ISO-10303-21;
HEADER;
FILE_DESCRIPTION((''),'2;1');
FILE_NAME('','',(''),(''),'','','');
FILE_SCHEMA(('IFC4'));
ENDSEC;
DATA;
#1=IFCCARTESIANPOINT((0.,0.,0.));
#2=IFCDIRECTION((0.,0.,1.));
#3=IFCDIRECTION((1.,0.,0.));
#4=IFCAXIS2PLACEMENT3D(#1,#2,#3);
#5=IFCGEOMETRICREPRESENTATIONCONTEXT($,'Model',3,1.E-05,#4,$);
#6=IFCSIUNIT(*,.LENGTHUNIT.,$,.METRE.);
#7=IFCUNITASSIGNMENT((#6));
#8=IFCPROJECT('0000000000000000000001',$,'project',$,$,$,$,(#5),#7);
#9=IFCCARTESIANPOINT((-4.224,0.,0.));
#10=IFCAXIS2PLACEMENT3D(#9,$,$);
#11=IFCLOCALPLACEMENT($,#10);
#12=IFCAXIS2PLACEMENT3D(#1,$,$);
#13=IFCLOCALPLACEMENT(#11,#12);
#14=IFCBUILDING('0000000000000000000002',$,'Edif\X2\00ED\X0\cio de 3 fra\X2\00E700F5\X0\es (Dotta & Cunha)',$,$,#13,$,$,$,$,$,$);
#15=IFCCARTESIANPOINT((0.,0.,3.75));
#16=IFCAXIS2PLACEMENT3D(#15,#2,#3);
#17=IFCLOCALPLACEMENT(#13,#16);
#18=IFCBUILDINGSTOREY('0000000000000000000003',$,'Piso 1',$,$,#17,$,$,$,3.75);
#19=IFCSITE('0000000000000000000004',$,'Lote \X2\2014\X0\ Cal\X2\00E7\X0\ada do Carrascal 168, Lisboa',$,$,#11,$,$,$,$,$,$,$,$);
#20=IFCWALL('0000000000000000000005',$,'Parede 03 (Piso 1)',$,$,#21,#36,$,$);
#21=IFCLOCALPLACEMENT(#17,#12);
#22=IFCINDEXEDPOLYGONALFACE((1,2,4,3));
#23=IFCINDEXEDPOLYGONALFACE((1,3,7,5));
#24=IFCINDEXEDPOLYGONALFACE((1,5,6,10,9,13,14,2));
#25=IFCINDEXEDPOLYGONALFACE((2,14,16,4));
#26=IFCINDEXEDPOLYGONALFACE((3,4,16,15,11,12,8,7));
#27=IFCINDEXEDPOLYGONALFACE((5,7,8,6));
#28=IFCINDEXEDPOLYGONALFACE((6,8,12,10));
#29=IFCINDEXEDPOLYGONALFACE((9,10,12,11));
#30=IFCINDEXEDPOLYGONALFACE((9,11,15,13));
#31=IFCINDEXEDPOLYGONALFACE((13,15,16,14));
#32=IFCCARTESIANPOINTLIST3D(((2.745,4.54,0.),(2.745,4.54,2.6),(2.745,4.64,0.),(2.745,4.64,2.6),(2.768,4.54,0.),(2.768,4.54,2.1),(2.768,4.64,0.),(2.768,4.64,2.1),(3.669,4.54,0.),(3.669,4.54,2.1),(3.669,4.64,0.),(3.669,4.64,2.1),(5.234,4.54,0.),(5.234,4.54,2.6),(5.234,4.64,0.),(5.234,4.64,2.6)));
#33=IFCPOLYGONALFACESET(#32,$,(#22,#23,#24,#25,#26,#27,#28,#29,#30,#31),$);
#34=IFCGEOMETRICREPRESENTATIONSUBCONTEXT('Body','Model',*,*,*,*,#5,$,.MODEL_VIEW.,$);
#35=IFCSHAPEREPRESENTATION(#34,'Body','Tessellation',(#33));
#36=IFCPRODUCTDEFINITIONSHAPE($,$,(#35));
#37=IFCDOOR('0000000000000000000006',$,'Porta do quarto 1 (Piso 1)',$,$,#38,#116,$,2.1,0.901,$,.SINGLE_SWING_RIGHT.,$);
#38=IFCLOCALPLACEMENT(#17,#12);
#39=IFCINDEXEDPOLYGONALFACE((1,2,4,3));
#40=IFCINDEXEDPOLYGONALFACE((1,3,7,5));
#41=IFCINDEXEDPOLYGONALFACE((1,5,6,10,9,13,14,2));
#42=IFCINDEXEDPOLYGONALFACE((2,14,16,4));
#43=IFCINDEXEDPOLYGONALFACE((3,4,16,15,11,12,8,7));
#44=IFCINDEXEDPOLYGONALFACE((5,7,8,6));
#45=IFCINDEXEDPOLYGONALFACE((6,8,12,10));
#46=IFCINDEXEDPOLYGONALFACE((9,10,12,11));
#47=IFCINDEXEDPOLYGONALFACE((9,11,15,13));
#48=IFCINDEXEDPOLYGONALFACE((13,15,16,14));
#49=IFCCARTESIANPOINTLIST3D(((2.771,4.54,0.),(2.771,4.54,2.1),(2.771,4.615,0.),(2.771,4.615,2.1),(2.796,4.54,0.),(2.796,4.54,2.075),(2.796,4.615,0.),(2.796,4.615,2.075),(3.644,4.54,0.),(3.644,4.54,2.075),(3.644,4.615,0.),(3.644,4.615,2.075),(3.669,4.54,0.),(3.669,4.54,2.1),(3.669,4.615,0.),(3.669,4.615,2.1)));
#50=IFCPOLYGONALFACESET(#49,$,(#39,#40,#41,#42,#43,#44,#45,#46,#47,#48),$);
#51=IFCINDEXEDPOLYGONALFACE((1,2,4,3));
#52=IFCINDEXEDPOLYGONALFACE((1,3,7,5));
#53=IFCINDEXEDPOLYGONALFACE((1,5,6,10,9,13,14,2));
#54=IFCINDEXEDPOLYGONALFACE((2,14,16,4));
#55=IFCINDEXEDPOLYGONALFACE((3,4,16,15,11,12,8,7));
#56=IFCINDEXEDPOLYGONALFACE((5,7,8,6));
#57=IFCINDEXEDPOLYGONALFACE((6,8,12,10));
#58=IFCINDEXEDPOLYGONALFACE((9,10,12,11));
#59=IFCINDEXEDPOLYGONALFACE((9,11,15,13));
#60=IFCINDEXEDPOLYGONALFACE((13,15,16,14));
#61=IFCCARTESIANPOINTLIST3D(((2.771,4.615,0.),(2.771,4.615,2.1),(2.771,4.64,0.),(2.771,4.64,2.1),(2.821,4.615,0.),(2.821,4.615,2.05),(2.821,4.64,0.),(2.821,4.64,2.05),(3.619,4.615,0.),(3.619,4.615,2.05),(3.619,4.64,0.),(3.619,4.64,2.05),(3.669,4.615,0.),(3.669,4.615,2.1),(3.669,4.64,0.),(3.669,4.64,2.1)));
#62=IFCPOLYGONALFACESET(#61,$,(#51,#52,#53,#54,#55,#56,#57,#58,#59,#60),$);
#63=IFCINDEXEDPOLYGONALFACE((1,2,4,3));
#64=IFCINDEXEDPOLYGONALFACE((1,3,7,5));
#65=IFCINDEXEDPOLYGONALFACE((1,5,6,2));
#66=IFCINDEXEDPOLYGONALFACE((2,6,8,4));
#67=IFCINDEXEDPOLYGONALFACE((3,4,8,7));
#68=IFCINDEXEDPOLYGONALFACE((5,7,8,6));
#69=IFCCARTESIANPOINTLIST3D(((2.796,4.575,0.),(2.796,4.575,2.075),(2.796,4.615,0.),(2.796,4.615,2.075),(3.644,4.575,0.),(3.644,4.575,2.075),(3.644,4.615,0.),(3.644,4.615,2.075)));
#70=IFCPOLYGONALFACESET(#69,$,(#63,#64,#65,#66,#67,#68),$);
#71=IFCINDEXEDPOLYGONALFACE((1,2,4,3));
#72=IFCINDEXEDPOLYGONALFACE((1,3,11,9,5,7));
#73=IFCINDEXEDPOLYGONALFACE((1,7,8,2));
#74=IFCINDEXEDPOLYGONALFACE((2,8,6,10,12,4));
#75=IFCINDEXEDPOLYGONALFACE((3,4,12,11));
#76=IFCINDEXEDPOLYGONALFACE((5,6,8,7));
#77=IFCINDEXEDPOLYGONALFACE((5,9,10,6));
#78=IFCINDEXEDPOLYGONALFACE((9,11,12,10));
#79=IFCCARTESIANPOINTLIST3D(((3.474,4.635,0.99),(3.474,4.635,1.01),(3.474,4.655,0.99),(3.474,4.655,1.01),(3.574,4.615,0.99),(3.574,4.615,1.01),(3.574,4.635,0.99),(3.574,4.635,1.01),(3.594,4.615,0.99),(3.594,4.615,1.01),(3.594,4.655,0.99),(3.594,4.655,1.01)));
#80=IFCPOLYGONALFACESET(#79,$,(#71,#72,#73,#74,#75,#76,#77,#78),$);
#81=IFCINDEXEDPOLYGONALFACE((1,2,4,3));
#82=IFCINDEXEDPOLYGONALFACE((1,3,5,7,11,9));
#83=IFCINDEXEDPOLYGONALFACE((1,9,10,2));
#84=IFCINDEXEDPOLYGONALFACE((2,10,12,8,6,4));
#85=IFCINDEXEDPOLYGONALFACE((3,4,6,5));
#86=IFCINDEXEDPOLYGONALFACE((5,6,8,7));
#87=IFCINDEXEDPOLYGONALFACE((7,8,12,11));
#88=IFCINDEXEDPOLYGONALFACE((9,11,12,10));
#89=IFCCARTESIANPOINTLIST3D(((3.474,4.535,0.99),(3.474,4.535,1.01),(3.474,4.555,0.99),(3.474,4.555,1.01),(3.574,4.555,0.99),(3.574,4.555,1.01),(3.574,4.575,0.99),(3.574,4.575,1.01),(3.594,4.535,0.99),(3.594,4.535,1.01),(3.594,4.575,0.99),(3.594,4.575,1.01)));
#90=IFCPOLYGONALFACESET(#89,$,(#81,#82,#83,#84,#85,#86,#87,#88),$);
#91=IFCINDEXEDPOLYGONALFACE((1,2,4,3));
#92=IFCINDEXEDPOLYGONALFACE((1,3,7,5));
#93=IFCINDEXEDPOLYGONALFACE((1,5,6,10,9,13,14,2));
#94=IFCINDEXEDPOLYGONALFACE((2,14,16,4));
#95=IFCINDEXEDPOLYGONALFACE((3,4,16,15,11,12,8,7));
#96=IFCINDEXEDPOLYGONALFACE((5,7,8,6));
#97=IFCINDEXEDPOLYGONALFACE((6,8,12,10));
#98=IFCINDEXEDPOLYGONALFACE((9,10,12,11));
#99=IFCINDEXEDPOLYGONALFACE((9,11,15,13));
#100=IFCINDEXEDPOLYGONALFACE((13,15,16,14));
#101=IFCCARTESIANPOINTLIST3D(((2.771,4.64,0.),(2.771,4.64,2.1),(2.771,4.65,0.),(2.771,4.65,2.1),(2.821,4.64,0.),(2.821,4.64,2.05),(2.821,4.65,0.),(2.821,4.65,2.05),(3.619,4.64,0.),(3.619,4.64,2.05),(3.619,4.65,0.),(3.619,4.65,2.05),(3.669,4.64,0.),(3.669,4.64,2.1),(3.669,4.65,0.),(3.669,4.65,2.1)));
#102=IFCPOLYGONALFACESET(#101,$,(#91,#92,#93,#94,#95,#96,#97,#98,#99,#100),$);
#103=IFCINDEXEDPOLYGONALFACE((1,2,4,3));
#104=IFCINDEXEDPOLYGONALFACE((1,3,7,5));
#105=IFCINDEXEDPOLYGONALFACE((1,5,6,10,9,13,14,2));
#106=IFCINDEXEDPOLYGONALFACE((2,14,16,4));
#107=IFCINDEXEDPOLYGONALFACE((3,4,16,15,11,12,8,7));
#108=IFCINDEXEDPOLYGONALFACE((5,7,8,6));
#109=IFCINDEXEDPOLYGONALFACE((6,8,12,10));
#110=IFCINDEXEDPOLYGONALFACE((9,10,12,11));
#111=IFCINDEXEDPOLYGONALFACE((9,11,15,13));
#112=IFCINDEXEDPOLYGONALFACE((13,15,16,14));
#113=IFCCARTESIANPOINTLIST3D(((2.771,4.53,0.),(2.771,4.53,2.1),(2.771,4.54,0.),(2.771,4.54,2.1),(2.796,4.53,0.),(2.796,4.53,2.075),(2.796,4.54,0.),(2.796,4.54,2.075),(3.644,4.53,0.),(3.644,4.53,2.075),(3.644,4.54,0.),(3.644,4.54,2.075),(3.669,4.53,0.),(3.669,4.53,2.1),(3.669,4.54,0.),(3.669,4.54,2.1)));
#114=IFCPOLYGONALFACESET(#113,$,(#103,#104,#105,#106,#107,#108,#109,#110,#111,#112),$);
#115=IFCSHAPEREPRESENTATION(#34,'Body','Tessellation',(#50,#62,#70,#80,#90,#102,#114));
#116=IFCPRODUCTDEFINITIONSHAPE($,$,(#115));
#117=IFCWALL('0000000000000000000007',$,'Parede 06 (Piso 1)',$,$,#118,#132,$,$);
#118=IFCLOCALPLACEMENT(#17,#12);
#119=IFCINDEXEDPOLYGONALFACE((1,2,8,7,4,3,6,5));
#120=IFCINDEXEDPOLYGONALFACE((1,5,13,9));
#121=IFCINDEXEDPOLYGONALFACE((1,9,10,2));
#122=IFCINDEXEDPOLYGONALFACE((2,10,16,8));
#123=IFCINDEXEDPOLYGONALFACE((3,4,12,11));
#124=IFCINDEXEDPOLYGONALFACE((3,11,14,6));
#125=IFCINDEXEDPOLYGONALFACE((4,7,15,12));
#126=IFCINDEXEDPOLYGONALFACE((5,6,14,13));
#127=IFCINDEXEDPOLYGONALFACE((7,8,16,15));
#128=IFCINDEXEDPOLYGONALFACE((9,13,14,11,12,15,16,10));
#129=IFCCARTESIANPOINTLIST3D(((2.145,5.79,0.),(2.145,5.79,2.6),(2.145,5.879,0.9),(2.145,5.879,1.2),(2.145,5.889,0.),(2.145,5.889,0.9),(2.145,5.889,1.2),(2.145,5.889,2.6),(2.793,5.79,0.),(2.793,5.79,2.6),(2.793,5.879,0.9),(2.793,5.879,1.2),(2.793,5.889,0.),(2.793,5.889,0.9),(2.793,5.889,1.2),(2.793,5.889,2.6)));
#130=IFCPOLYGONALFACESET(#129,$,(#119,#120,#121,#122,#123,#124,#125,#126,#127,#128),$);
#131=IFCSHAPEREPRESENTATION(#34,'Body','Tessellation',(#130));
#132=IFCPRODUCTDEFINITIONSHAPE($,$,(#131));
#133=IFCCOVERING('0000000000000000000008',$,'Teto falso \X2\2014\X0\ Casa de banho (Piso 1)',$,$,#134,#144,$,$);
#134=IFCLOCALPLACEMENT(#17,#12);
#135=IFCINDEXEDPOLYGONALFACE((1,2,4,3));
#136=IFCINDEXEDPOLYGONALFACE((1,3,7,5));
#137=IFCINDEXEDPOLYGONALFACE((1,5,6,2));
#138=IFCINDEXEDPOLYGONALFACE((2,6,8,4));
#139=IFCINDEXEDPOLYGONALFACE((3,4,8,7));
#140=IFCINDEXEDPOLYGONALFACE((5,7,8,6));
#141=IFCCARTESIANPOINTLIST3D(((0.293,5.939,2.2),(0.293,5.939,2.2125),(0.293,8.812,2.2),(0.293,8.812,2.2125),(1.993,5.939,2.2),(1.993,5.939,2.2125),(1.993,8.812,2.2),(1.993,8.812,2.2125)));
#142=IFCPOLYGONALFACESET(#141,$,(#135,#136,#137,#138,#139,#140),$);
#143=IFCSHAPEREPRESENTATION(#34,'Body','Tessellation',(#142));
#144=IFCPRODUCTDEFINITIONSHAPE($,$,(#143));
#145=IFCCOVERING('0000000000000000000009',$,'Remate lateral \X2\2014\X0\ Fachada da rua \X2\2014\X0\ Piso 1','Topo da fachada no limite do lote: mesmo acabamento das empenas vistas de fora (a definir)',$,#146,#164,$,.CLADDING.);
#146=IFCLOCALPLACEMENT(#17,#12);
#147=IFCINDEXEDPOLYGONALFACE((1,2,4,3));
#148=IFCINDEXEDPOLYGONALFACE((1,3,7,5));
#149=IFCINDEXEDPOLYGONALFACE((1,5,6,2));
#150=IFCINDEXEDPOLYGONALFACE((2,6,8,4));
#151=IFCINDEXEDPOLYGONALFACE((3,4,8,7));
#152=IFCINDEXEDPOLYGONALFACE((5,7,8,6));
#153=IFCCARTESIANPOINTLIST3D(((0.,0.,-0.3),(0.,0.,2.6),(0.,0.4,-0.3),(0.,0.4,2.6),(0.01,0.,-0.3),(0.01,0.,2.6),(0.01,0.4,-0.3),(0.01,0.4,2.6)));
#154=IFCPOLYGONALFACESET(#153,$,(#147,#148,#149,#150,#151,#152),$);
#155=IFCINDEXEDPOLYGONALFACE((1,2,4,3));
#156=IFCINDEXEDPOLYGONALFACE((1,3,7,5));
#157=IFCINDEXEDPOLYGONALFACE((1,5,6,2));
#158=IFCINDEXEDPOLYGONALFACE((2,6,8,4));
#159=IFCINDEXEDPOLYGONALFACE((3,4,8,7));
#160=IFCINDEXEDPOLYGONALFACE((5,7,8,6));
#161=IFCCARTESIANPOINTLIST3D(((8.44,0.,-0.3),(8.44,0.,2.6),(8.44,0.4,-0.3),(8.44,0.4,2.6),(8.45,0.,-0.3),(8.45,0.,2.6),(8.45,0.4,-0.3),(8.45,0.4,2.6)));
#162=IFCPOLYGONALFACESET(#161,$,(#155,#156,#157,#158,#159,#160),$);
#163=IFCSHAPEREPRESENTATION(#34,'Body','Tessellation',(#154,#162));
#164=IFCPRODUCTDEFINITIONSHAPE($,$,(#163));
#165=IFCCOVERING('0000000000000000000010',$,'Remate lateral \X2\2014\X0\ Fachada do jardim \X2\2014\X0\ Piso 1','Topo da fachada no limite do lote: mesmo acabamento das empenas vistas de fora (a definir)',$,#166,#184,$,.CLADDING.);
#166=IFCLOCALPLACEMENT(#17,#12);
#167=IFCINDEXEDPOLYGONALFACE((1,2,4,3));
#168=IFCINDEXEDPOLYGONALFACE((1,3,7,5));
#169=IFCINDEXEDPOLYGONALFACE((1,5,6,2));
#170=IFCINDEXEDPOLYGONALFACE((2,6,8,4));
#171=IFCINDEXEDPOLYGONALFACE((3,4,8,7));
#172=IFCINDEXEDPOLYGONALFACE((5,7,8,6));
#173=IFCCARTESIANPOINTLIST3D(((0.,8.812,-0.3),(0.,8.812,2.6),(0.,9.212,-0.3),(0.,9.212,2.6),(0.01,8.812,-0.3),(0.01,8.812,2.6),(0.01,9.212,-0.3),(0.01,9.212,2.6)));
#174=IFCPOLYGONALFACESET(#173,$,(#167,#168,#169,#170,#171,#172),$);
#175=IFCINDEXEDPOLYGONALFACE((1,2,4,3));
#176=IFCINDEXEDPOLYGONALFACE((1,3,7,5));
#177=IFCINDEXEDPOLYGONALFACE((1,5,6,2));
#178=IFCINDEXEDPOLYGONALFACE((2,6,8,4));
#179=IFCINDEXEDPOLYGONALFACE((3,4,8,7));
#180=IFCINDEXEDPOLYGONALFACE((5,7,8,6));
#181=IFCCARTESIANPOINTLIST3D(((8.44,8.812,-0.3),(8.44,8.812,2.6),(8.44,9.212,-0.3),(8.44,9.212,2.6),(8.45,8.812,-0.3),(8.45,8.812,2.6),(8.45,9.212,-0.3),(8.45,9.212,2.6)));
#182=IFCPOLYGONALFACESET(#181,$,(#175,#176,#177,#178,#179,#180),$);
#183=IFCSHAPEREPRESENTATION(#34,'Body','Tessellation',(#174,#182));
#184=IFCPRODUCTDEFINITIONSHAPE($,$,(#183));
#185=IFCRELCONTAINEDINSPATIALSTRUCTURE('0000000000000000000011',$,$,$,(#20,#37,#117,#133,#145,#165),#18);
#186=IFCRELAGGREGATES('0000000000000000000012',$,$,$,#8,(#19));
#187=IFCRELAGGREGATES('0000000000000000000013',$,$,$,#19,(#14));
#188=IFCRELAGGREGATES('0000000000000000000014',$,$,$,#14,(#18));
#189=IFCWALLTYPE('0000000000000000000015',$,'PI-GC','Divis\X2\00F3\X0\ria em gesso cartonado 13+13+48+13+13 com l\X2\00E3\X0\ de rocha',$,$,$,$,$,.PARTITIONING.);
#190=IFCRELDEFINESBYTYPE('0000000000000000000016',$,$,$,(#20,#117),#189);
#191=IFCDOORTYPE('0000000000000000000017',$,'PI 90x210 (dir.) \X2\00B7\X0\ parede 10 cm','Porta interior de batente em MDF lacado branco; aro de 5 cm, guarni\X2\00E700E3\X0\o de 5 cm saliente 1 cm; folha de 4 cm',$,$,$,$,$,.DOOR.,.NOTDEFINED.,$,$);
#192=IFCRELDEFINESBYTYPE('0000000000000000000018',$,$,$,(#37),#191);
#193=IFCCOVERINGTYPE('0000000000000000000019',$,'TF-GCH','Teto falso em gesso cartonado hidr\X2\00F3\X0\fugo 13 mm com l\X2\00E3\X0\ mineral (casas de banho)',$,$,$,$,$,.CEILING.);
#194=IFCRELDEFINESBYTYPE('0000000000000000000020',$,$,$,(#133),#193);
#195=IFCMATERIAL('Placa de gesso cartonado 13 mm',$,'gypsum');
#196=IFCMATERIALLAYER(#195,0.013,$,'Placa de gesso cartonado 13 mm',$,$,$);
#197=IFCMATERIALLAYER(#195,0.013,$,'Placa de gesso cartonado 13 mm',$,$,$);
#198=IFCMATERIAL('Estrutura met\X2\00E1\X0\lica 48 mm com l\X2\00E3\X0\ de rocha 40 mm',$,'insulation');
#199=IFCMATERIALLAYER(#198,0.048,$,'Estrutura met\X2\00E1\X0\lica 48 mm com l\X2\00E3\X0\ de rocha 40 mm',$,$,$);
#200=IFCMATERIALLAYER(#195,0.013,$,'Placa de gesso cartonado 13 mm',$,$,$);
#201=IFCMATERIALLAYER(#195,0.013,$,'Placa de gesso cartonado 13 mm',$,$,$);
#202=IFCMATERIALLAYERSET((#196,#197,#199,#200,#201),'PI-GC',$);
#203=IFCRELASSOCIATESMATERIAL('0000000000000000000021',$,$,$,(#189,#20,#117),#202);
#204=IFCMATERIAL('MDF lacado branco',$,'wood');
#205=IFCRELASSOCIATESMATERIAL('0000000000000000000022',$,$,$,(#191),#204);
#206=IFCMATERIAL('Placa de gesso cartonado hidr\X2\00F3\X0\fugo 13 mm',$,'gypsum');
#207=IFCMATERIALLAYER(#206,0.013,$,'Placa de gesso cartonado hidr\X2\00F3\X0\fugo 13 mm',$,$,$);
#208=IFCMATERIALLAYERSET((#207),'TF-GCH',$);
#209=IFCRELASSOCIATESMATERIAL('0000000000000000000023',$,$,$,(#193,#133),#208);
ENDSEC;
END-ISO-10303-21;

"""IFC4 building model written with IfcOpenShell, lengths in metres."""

from ifc_helpers import new_model, si_unit, frame, origin, origin_with_axes, place, context, subcontext, project, spatial, line, indexed_curve, outline, extrude, source, transform, mapped, material, layer, layer_set, layer_usage, type_object, type_shapes, element, fill, save


model = new_model("IFC4")

# Units and contexts
model_context = context("Model", 3, precision=1e-05, world=origin_with_axes())
body_context = subcontext(model_context, "Body", "Model", "MODEL_VIEW")
ifc_project = project(units=[si_unit("LENGTHUNIT", "METRE")], contexts=[model_context])

# Site, building, storey
site_placement = place(None, frame((-4.224, 0.0, 0.0)))
site = spatial("IfcSite", under=ifc_project, at=site_placement, Name="Lote — Calçada do Carrascal 168, Lisboa")
building_placement = place(site_placement, origin())
building = spatial("IfcBuilding", under=site, at=building_placement, Name="Edifício de 3 frações (Dotta & Cunha)")
storey_placement = place(building_placement, frame((0.0, 0.0, 3.75), z_axis=(0.0, 0.0, 1.0), x_axis=(1.0, 0.0, 0.0)))
storey = spatial("IfcBuildingStorey", under=building, at=storey_placement, Name="Piso 1", Elevation=3.75)

# Shared definitions
ifc_material_1 = material(Name="MDF lacado branco", Category="wood")

# Shared definitions
ifc_material_2 = material(Name="Placa de gesso cartonado 13 mm", Category="gypsum")
ifc_layer_1 = layer(ifc_material_2, 0.013, Name="Placa de gesso cartonado 13 mm")
ifc_layer_2 = layer(ifc_material_2, 0.013, Name="Placa de gesso cartonado 13 mm")
ifc_material_3 = material(Name="Estrutura metálica 48 mm com lã de rocha 40 mm", Category="insulation")
ifc_layer_3 = layer(ifc_material_3, 0.048, Name="Estrutura metálica 48 mm com lã de rocha 40 mm")
ifc_layer_4 = layer(ifc_material_2, 0.013, Name="Placa de gesso cartonado 13 mm")
ifc_layer_5 = layer(ifc_material_2, 0.013, Name="Placa de gesso cartonado 13 mm")
ifc_layer_set_1 = layer_set([ifc_layer_1, ifc_layer_2, ifc_layer_3, ifc_layer_4, ifc_layer_5], Name="PI-GC")
wall_type_1 = type_object("IfcWallType", Name="PI-GC", Description="Divisória em gesso cartonado 13+13+48+13+13 com lã de rocha", PredefinedType="PARTITIONING", material=ifc_layer_set_1)

# Wall, opening, door
door_type_1 = type_object("IfcDoorType", Name="PI 90x210 (dir.) · parede 10 cm", Description="Porta interior de batente em MDF lacado branco; aro de 5 cm, guarnição de 5 cm saliente 1 cm; folha de 4 cm", OperationType="NOTDEFINED", PredefinedType="DOOR", material=ifc_material_1)
shared_shape_1 = source(origin_with_axes(), body_context, "Body", "SweptSolid", [
    extrude(outline(indexed_curve([(0.0, 0.0), (0.0, 2.1), (0.898, 2.1), (0.898, 0.0), (0.873, 0.0), (0.873, 2.075), (0.025, 2.075), (0.025, 0.0)], segments=[line(1, 2, 3, 4, 5, 6, 7, 8, 1)])), frame((0.0, 0.025, 0.0), z_axis=(0.0, -1.0, 0.0), x_axis=(1.0, 0.0, 0.0)), (0.0, 0.0, -1.0), 0.075),
    extrude(outline(indexed_curve([(0.0, 0.0), (0.0, 2.1), (0.898, 2.1), (0.898, 0.0), (0.848, 0.0), (0.848, 2.05), (0.05, 2.05), (0.05, 0.0)], segments=[line(1, 2, 3, 4, 5, 6, 7, 8, 1)])), frame((0.0, 0.0, 0.0), z_axis=(0.0, -1.0, 0.0), x_axis=(1.0, 0.0, 0.0)), (0.0, 0.0, -1.0), 0.025),
    extrude(outline(indexed_curve([(0.0, 0.0), (0.848, 0.0), (0.848, 0.04), (0.0, 0.04)], segments=[line(1, 2, 3, 4, 1)])), frame((0.025, 0.025, 0.0), z_axis=(0.0, 0.0, 1.0), x_axis=(1.0, 0.0, 0.0)), (0.0, 0.0, 1.0), 2.075),
    extrude(outline(indexed_curve([(0.0, 0.0), (0.0, -0.04), (0.12, -0.04), (0.12, -0.02), (0.02, -0.02), (0.02, 0.0)], segments=[line(1, 2, 3, 4, 5, 6, 1)])), frame((0.075, 0.025, 0.99), z_axis=(0.0, 0.0, 1.0), x_axis=(1.0, 0.0, 0.0)), (0.0, 0.0, 1.0), 0.02),
    extrude(outline(indexed_curve([(0.0, 0.0), (0.0, 0.04), (0.12, 0.04), (0.12, 0.02), (0.02, 0.02), (0.02, 0.0)], segments=[line(1, 2, 3, 4, 5, 6, 1)])), frame((0.075, 0.065, 0.99), z_axis=(0.0, 0.0, 1.0), x_axis=(1.0, 0.0, 0.0)), (0.0, 0.0, 1.0), 0.02),
    extrude(outline(indexed_curve([(0.0, 0.0), (0.0, 2.1), (0.898, 2.1), (0.898, 0.0), (0.848, 0.0), (0.848, 2.05), (0.05, 2.05), (0.05, 0.0)], segments=[line(1, 2, 3, 4, 5, 6, 7, 8, 1)])), frame((0.0, -0.01, 0.0), z_axis=(0.0, -1.0, 0.0), x_axis=(1.0, 0.0, 0.0)), (0.0, 0.0, -1.0), 0.01),
    extrude(outline(indexed_curve([(0.0, 0.0), (0.0, 2.1), (0.898, 2.1), (0.898, 0.0), (0.873, 0.0), (0.873, 2.075), (0.025, 2.075), (0.025, 0.0)], segments=[line(1, 2, 3, 4, 5, 6, 7, 8, 1)])), frame((0.0, 0.1, 0.0), z_axis=(0.0, -1.0, 0.0), x_axis=(1.0, 0.0, 0.0)), (0.0, 0.0, -1.0), 0.01),
])
type_shapes(door_type_1, [shared_shape_1])
ifc_layer_usage_1 = layer_usage(ifc_layer_set_1, "AXIS2", "POSITIVE", 0.0)
wall_1_placement = place(storey_placement, origin_with_axes())
wall_1 = element("IfcWall", 1, at=wall_1_placement, inside=storey, type_object=wall_type_1, material=ifc_layer_usage_1, Name="Parede 03 (Piso 1)", context=body_context, shape_type="SweptSolid", body=[
    extrude(outline(indexed_curve([(5.234, 4.54), (5.234, 4.64), (2.745, 4.64), (2.745, 4.54)], segments=[line(1, 2, 3, 4, 1)])), origin_with_axes(), (0.0, 0.0, 1.0), 2.6),
])
opening_1_placement = place(wall_1_placement, origin_with_axes())
opening_1 = element("IfcOpeningElement", 2, at=opening_1_placement, cuts=wall_1, context=body_context, shape_type="SweptSolid", body=[
    extrude(outline(indexed_curve([(3.669, 4.538), (3.669, 4.642), (2.768, 4.642), (2.768, 4.538)], segments=[line(1, 2, 3, 4, 1)])), origin_with_axes(), (0.0, 0.0, 1.0), 2.1),
])
door_1_placement = place(storey_placement, frame((3.669, 4.64, 0.0), z_axis=(0.0, 0.0, 1.0), x_axis=(-1.0, 0.0, 0.0)))
door_1 = element("IfcDoor", 3, at=door_1_placement, inside=storey, type_object=door_type_1, Name="Porta do quarto 1 (Piso 1)", OperationType="SINGLE_SWING_RIGHT", OverallHeight=2.1, OverallWidth=0.901, context=body_context, shape_type="MappedRepresentation", body=[
    mapped(shared_shape_1, transform((0.0, 0.0, 0.0), x_axis=(1.0, 0.0, 0.0), y_axis=(0.0, 1.0, 0.0), z_axis=(0.0, 0.0, 1.0), scale=1.0)),
])
fill(opening_1, door_1)

# Wall, opening
ifc_layer_usage_2 = layer_usage(ifc_layer_set_1, "AXIS2", "POSITIVE", 0.0)
wall_2_placement = place(storey_placement, origin_with_axes())
wall_2 = element("IfcWall", 4, at=wall_2_placement, inside=storey, type_object=wall_type_1, material=ifc_layer_usage_2, Name="Parede 06 (Piso 1)", context=body_context, shape_type="SweptSolid", body=[
    extrude(outline(indexed_curve([(2.793, 5.79), (2.793, 5.889), (2.145, 5.889), (2.145, 5.79)], segments=[line(1, 2, 3, 4, 1)])), origin_with_axes(), (0.0, 0.0, 1.0), 2.6),
])
opening_2_placement = place(wall_2_placement, frame((0.0, 0.0, 0.9), z_axis=(0.0, 0.0, 1.0), x_axis=(1.0, 0.0, 0.0)))
element("IfcOpeningElement", 5, at=opening_2_placement, cuts=wall_2, PredefinedType="RECESS", context=body_context, shape_type="SweptSolid", body=[
    extrude(outline(indexed_curve([(2.793, 5.879), (2.793, 5.894), (2.145, 5.894), (2.145, 5.879)], segments=[line(1, 2, 3, 4, 1)])), origin_with_axes(), (0.0, 0.0, 1.0), 0.3),
])

# Coverings
ifc_material_4 = material(Name="Placa de gesso cartonado hidrófugo 13 mm", Category="gypsum")
ifc_layer_6 = layer(ifc_material_4, 0.013, Name="Placa de gesso cartonado hidrófugo 13 mm")
ifc_layer_set_2 = layer_set([ifc_layer_6], Name="TF-GCH")
ifc_layer_usage_3 = layer_usage(ifc_layer_set_2, "AXIS3", "POSITIVE", 0.0)
covering_type_1 = type_object("IfcCoveringType", Name="TF-GCH", Description="Teto falso em gesso cartonado hidrófugo 13 mm com lã mineral (casas de banho)", PredefinedType="CEILING", material=ifc_layer_set_2)
covering_1_placement = place(storey_placement, frame((0.0, 0.0, 2.2), z_axis=(0.0, 0.0, 1.0), x_axis=(1.0, 0.0, 0.0)))
element("IfcCovering", 6, at=covering_1_placement, inside=storey, type_object=covering_type_1, material=ifc_layer_usage_3, Name="Teto falso — Casa de banho (Piso 1)", context=body_context, shape_type="SweptSolid", body=[
    extrude(outline(indexed_curve([(0.293, 8.812), (1.993, 8.812), (1.993, 5.939), (0.293, 5.939)], segments=[line(1, 2, 3, 4, 1)])), origin_with_axes(), (0.0, 0.0, 1.0), 0.0125),
])
covering_2_placement = place(storey_placement, frame((0.0, 0.0, -0.3), z_axis=(0.0, 0.0, 1.0), x_axis=(1.0, 0.0, 0.0)))
element("IfcCovering", 7, at=covering_2_placement, inside=storey, Name="Remate lateral — Fachada da rua — Piso 1", Description="Topo da fachada no limite do lote: mesmo acabamento das empenas vistas de fora (a definir)", PredefinedType="CLADDING", context=body_context, shape_type="SweptSolid", body=[
    extrude(outline(indexed_curve([(0.0, 0.0), (0.0, 0.4), (0.01, 0.4), (0.01, 0.0)], segments=[line(1, 2, 3, 4, 1)])), origin_with_axes(), (0.0, 0.0, 1.0), 2.9),
    extrude(outline(indexed_curve([(8.44, 0.0), (8.44, 0.4), (8.45, 0.4), (8.45, 0.0)], segments=[line(1, 2, 3, 4, 1)])), origin_with_axes(), (0.0, 0.0, 1.0), 2.9),
])
covering_3_placement = place(storey_placement, frame((0.0, 0.0, -0.3), z_axis=(0.0, 0.0, 1.0), x_axis=(1.0, 0.0, 0.0)))
element("IfcCovering", 8, at=covering_3_placement, inside=storey, Name="Remate lateral — Fachada do jardim — Piso 1", Description="Topo da fachada no limite do lote: mesmo acabamento das empenas vistas de fora (a definir)", PredefinedType="CLADDING", context=body_context, shape_type="SweptSolid", body=[
    extrude(outline(indexed_curve([(0.0, 8.812), (0.0, 9.212), (0.01, 9.212), (0.01, 8.812)], segments=[line(1, 2, 3, 4, 1)])), origin_with_axes(), (0.0, 0.0, 1.0), 2.9),
    extrude(outline(indexed_curve([(8.44, 8.812), (8.44, 9.212), (8.45, 9.212), (8.45, 8.812)], segments=[line(1, 2, 3, 4, 1)])), origin_with_axes(), (0.0, 0.0, 1.0), 2.9),
])

save(model, "model.ifc")
